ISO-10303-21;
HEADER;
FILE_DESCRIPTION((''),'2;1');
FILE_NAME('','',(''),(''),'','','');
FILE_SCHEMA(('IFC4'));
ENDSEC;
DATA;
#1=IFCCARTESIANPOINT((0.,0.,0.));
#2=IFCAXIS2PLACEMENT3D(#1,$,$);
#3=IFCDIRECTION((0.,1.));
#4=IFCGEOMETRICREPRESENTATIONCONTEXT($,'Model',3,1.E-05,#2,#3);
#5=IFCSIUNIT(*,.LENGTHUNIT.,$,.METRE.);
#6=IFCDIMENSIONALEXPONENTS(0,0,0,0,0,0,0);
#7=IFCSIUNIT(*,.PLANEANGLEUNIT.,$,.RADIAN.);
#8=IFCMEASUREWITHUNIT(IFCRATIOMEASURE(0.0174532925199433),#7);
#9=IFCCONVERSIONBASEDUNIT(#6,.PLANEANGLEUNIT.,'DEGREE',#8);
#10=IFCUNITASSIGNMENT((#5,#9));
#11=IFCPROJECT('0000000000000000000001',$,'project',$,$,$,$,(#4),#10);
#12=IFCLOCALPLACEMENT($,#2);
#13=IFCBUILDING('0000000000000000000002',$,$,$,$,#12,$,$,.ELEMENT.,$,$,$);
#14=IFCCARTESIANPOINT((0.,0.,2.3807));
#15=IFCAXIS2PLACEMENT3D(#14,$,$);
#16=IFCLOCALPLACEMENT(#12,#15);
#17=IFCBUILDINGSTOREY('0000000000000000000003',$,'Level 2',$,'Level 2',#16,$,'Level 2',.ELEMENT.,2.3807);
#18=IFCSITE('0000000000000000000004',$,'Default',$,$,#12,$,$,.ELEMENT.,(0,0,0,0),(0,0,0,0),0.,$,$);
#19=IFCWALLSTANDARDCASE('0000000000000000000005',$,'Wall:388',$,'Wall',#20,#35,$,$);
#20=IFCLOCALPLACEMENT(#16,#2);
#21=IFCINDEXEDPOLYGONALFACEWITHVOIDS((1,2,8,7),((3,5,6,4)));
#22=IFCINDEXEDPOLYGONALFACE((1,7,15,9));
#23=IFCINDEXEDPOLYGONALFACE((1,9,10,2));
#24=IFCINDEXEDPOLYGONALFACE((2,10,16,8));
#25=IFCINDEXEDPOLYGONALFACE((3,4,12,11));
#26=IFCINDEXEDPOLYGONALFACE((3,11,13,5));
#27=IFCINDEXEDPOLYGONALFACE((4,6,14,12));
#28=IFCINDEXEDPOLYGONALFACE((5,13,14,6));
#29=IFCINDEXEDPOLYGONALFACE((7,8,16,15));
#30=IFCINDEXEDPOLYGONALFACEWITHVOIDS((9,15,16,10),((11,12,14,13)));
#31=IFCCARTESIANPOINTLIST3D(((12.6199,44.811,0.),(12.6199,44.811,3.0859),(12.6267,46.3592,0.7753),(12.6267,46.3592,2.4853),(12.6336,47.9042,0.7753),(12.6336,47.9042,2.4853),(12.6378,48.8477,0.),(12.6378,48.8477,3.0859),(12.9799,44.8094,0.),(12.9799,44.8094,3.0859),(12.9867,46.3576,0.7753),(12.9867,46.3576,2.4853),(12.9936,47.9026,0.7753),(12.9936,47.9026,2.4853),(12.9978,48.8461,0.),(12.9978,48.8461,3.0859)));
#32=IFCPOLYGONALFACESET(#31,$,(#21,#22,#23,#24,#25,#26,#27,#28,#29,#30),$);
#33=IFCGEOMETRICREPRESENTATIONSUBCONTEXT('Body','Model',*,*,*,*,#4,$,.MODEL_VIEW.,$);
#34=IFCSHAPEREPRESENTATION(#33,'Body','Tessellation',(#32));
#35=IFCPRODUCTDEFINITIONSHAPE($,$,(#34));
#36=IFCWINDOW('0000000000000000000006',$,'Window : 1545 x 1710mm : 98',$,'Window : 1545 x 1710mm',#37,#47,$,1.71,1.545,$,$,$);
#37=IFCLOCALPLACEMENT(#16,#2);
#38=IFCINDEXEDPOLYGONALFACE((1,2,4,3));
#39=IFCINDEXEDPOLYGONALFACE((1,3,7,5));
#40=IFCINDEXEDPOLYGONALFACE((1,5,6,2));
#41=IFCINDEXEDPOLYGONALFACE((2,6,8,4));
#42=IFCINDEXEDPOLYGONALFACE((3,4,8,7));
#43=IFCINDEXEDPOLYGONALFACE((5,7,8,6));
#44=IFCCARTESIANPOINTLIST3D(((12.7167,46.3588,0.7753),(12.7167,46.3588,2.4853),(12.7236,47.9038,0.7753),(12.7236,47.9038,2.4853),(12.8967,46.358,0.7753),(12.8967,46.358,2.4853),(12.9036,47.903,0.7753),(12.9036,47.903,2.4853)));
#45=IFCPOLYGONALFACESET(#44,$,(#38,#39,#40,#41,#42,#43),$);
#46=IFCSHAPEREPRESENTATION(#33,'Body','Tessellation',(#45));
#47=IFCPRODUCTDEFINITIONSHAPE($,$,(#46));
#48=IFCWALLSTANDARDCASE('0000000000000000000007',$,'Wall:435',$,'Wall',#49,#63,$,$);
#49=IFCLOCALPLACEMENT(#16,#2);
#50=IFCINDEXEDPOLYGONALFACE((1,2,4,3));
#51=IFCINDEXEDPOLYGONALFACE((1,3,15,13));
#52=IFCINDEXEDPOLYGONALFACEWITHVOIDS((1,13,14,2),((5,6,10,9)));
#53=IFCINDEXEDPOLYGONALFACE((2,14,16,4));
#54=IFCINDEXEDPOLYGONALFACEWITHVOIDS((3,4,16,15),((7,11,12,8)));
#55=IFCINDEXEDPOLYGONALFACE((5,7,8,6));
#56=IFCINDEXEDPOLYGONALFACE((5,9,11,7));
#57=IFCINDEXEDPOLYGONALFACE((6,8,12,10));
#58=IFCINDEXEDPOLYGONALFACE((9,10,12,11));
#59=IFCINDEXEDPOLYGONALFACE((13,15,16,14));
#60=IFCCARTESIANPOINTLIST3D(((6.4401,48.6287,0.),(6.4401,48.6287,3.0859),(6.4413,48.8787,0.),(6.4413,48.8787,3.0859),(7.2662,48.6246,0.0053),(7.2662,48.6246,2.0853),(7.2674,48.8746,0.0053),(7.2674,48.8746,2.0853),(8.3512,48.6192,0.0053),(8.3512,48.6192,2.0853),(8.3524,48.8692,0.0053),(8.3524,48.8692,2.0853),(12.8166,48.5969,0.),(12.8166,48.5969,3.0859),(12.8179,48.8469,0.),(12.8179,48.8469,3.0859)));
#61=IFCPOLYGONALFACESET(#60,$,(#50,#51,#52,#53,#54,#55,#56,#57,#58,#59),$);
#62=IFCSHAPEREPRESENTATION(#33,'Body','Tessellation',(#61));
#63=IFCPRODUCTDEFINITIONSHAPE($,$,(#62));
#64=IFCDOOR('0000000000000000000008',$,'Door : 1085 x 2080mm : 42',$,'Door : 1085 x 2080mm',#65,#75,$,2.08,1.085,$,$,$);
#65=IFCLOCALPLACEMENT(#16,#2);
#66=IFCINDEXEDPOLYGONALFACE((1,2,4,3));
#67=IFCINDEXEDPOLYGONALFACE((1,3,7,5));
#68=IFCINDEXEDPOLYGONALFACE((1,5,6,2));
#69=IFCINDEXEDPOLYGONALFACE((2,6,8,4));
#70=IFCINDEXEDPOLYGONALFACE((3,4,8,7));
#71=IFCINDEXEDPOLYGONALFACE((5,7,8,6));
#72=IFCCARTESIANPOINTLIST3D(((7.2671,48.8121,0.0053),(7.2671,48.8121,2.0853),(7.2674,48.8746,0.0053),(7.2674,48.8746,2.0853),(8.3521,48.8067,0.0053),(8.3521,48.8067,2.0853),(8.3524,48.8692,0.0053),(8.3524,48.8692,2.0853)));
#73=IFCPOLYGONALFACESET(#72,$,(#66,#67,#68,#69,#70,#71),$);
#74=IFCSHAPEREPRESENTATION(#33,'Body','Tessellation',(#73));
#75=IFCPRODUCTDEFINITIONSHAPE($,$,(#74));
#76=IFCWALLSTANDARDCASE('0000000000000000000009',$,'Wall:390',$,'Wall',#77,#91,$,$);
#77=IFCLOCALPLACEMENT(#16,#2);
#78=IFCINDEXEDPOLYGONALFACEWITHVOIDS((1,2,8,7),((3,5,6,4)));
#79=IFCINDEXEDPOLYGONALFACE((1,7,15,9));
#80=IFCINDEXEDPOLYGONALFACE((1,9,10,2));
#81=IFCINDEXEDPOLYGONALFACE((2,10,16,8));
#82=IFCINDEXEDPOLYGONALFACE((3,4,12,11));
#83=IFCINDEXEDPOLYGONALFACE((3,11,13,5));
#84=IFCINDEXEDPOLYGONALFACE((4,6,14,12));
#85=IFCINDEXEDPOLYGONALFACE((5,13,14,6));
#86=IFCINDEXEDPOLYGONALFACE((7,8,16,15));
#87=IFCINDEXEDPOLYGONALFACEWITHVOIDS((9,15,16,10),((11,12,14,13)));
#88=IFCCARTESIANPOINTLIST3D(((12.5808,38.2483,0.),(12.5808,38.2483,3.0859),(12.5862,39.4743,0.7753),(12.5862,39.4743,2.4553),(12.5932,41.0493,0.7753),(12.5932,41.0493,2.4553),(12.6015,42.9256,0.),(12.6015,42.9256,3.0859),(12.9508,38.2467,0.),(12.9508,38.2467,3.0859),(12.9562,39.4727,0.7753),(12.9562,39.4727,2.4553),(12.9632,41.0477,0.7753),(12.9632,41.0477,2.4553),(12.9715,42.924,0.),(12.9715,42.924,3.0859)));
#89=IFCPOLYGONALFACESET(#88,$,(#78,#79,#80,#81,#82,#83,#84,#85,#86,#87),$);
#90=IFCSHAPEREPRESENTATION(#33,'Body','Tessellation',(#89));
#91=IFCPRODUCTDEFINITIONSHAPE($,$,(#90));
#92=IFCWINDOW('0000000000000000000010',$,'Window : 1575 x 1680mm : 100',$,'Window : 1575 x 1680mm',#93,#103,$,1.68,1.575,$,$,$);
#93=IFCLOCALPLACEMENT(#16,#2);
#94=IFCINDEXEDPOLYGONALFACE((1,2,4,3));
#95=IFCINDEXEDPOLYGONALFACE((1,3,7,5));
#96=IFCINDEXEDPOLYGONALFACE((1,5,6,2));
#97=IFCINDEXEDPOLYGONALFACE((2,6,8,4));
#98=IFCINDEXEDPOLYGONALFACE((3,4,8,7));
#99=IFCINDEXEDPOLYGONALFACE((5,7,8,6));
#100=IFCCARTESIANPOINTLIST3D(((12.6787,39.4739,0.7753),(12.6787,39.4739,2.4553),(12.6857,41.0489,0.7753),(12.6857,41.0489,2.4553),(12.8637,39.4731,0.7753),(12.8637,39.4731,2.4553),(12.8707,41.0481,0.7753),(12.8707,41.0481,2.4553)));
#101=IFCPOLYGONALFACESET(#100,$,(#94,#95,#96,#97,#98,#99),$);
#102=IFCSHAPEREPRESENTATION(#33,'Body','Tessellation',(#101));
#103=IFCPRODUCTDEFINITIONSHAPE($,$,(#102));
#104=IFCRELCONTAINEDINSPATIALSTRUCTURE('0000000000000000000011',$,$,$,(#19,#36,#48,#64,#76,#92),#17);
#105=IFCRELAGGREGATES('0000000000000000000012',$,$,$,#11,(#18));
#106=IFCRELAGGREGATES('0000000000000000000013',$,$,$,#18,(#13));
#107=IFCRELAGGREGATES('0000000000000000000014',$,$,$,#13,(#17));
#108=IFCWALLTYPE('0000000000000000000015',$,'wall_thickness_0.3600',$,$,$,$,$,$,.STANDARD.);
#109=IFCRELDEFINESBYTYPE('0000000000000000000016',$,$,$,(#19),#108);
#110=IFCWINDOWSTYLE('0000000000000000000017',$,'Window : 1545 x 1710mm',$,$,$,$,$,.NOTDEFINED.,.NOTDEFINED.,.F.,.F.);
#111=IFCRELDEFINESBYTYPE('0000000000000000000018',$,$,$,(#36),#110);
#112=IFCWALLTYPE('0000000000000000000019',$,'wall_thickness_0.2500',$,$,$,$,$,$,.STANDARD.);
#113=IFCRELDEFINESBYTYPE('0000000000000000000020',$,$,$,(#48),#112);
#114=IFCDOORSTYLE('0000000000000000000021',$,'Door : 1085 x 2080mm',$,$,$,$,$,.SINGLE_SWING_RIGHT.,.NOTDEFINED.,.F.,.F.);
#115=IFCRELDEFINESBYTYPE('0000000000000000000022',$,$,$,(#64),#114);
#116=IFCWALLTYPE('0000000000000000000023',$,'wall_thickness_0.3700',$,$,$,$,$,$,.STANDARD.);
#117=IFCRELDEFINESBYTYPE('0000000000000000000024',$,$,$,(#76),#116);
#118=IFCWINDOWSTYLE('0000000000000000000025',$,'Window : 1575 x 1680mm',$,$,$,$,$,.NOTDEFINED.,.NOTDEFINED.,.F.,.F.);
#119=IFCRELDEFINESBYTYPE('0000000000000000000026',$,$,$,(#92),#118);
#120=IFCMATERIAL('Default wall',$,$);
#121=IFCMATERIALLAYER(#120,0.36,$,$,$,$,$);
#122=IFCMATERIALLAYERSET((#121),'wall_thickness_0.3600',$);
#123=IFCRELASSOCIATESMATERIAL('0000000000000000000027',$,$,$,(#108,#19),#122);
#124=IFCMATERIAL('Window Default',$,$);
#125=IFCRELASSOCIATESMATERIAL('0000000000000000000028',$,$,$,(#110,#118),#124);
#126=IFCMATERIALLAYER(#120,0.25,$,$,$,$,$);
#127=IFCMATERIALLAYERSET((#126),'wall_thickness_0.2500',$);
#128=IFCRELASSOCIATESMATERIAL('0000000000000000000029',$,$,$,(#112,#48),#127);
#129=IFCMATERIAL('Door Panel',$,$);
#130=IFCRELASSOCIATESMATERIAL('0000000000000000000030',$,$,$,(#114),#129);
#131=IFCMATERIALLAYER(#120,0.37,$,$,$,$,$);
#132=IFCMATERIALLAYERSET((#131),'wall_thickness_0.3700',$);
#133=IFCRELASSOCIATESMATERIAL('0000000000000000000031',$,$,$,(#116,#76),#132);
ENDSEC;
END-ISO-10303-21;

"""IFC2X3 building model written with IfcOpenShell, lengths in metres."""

from ifc_helpers import new_model, entity, si_unit, converted_unit, direction, frame, frame_2d, origin, origin_2d_with_axis, place, context, subcontext, project, spatial, polyline, rectangle, outline, extrude, source, transform, mapped, material, layer, layer_set, layer_usage, type_object, type_shapes, element, fill, save


model = new_model("IFC2X3")

# Units and contexts
model_context = context("Model", 3, precision=1e-05, world=origin(), true_north=direction((0.0, 1.0)))
body_context = subcontext(model_context, "Body", "Model", "MODEL_VIEW")
ifc_project = project(units=[si_unit("LENGTHUNIT", "METRE"), converted_unit("PLANEANGLEUNIT", "DEGREE", entity("IfcRatioMeasure", 0.0174532925199433), si_unit("PLANEANGLEUNIT", "RADIAN"), dimensions=[0, 0, 0, 0, 0, 0, 0])], contexts=[model_context])

# Site, building, storey
placement_1 = place(None, origin())
site = spatial("IfcSite", under=ifc_project, at=placement_1, Name="Default", CompositionType="ELEMENT", RefLatitude=(0, 0, 0, 0), RefLongitude=(0, 0, 0, 0), RefElevation=0.0)
building = spatial("IfcBuilding", under=site, at=placement_1, CompositionType="ELEMENT")
storey_placement = place(placement_1, frame((0.0, 0.0, 2.3807)))
storey = spatial("IfcBuildingStorey", under=building, at=storey_placement, Name="Level 2", ObjectType="Level 2", LongName="Level 2", CompositionType="ELEMENT", Elevation=2.3807)

# Wall, opening, window
ifc_material_1 = material(Name="Default wall")
ifc_layer_1 = layer(ifc_material_1, 0.36)
ifc_layer_set_1 = layer_set([ifc_layer_1], Name="wall_thickness_0.3600")
ifc_layer_usage_1 = layer_usage(ifc_layer_set_1, "AXIS2", "POSITIVE", -0.18)
wall_type_1 = type_object("IfcWallType", Name="wall_thickness_0.3600", PredefinedType="STANDARD", material=ifc_layer_set_1)
wall_1_placement = place(storey_placement, frame((12.8178, 48.8469, 0.0), z_axis=(0.0, 0.0, 1.0), x_axis=(-0.004434, -0.99999, 0.0)))
wall_1 = element("IfcWallStandardCase", 1, at=wall_1_placement, inside=storey, type_object=wall_type_1, material=ifc_layer_usage_1, Name="Wall:388", ObjectType="Wall", context=body_context, shape_type="SweptSolid", body=[
    extrude(outline(polyline([(4.0368, -0.18), (4.0368, 0.18), (0.0, 0.18), (0.0, -0.18), (4.0368, -0.18)])), origin(), (0.0, 0.0, 1.0), 3.0859),
])
opening_1_placement = place(wall_1_placement, frame((0.9435, -0.18, 0.7753)))
opening_1 = element("IfcOpeningElement", 2, at=opening_1_placement, cuts=wall_1, ObjectType="Opening", context=body_context, shape_type="SweptSolid", body=[
    extrude(rectangle(XDim=1.545, YDim=1.71, at=frame_2d((0.855, 0.7725), x_axis=(0.0, 1.0))), frame((0.0, 0.0, 0.0), z_axis=(0.0, 1.0, 0.0), x_axis=(0.0, 0.0, 1.0)), (0.0, 0.0, 1.0), 0.36),
])
ifc_material_2 = material(Name="Window Default")
window_style_1 = type_object("IfcWindowStyle", Name="Window : 1545 x 1710mm", ConstructionType="NOTDEFINED", OperationType="NOTDEFINED", ParameterTakesPrecedence=False, Sizeable=False, material=ifc_material_2)
shared_shape_1 = source(origin(), body_context, "Body", "SweptSolid", [
    extrude(rectangle(XDim=0.18, YDim=1.545, at=origin_2d_with_axis()), frame((0.7725, 0.18, 0.0), z_axis=(0.0, 0.0, 1.0), x_axis=(0.0, 1.0, 0.0)), (0.0, 0.0, 1.0), 1.71),
])
type_shapes(window_style_1, [shared_shape_1])
window_1_placement = place(opening_1_placement, origin())
window_1 = element("IfcWindow", 3, at=window_1_placement, inside=storey, type_object=window_style_1, Name="Window : 1545 x 1710mm : 98", ObjectType="Window : 1545 x 1710mm", OverallHeight=1.71, OverallWidth=1.545, context=body_context, shape_type="MappedRepresentation", body=[
    mapped(shared_shape_1, transform((0.0, 0.0, 0.0), scale=1.0)),
])
fill(opening_1, window_1)

# Wall, opening, door
ifc_layer_2 = layer(ifc_material_1, 0.25)
ifc_layer_set_2 = layer_set([ifc_layer_2], Name="wall_thickness_0.2500")
ifc_layer_usage_2 = layer_usage(ifc_layer_set_2, "AXIS2", "POSITIVE", -0.125)
wall_type_2 = type_object("IfcWallType", Name="wall_thickness_0.2500", PredefinedType="STANDARD", material=ifc_layer_set_2)
wall_2_placement = place(storey_placement, frame((6.4407, 48.7537, 0.0), z_axis=(0.0, 0.0, 1.0), x_axis=(0.999988, -0.004987, 0.0)))
wall_2 = element("IfcWallStandardCase", 4, at=wall_2_placement, inside=storey, type_object=wall_type_2, material=ifc_layer_usage_2, Name="Wall:435", ObjectType="Wall", context=body_context, shape_type="SweptSolid", body=[
    extrude(outline(polyline([(6.3766, -0.125), (6.3766, 0.125), (0.0, 0.125), (0.0, -0.125), (6.3766, -0.125)])), origin(), (0.0, 0.0, 1.0), 3.0859),
])
opening_2_placement = place(wall_2_placement, frame((0.8261, -0.125, 0.0053)))
opening_2 = element("IfcOpeningElement", 5, at=opening_2_placement, cuts=wall_2, ObjectType="Opening", context=body_context, shape_type="SweptSolid", body=[
    extrude(rectangle(XDim=1.085, YDim=2.08, at=frame_2d((1.04, 0.5425), x_axis=(0.0, 1.0))), frame((0.0, 0.0, 0.0), z_axis=(0.0, 1.0, 0.0), x_axis=(0.0, 0.0, 1.0)), (0.0, 0.0, 1.0), 0.25),
])
ifc_material_3 = material(Name="Door Panel")
door_style = type_object("IfcDoorStyle", Name="Door : 1085 x 2080mm", ConstructionType="NOTDEFINED", OperationType="SINGLE_SWING_RIGHT", ParameterTakesPrecedence=False, Sizeable=False, material=ifc_material_3)
shared_shape_2 = source(origin(), body_context, "Body", "SweptSolid", [
    extrude(rectangle(XDim=0.0625, YDim=1.085, at=origin_2d_with_axis()), frame((0.5425, 0.2188, 0.0), z_axis=(0.0, 0.0, 1.0), x_axis=(0.0, 1.0, 0.0)), (0.0, 0.0, 1.0), 2.08),
])
type_shapes(door_style, [shared_shape_2])
door_placement = place(opening_2_placement, origin())
door = element("IfcDoor", 6, at=door_placement, inside=storey, type_object=door_style, Name="Door : 1085 x 2080mm : 42", ObjectType="Door : 1085 x 2080mm", OverallHeight=2.08, OverallWidth=1.085, context=body_context, shape_type="MappedRepresentation", body=[
    mapped(shared_shape_2, transform((0.0, 0.0, 0.0), scale=1.0)),
])
fill(opening_2, door)

# Wall, opening, window
ifc_layer_3 = layer(ifc_material_1, 0.37)
ifc_layer_set_3 = layer_set([ifc_layer_3], Name="wall_thickness_0.3700")
ifc_layer_usage_3 = layer_usage(ifc_layer_set_3, "AXIS2", "POSITIVE", -0.185)
wall_type_3 = type_object("IfcWallType", Name="wall_thickness_0.3700", PredefinedType="STANDARD", material=ifc_layer_set_3)
wall_3_placement = place(storey_placement, frame((12.7865, 42.9248, 0.0), z_axis=(0.0, 0.0, 1.0), x_axis=(-0.004434, -0.99999, 0.0)))
wall_3 = element("IfcWallStandardCase", 7, at=wall_3_placement, inside=storey, type_object=wall_type_3, material=ifc_layer_usage_3, Name="Wall:390", ObjectType="Wall", context=body_context, shape_type="SweptSolid", body=[
    extrude(outline(polyline([(4.6773, -0.185), (4.6773, 0.185), (0.0, 0.185), (0.0, -0.185), (4.6773, -0.185)])), origin(), (0.0, 0.0, 1.0), 3.0859),
])
opening_3_placement = place(wall_3_placement, frame((1.8763, -0.185, 0.7753)))
opening_3 = element("IfcOpeningElement", 8, at=opening_3_placement, cuts=wall_3, ObjectType="Opening", context=body_context, shape_type="SweptSolid", body=[
    extrude(rectangle(XDim=1.575, YDim=1.68, at=frame_2d((0.84, 0.7875), x_axis=(0.0, 1.0))), frame((0.0, 0.0, 0.0), z_axis=(0.0, 1.0, 0.0), x_axis=(0.0, 0.0, 1.0)), (0.0, 0.0, 1.0), 0.37),
])
window_style_2 = type_object("IfcWindowStyle", Name="Window : 1575 x 1680mm", ConstructionType="NOTDEFINED", OperationType="NOTDEFINED", ParameterTakesPrecedence=False, Sizeable=False, material=ifc_material_2)
shared_shape_3 = source(origin(), body_context, "Body", "SweptSolid", [
    extrude(rectangle(XDim=0.185, YDim=1.575, at=origin_2d_with_axis()), frame((0.7875, 0.185, 0.0), z_axis=(0.0, 0.0, 1.0), x_axis=(0.0, 1.0, 0.0)), (0.0, 0.0, 1.0), 1.68),
])
type_shapes(window_style_2, [shared_shape_3])
window_2_placement = place(opening_3_placement, origin())
window_2 = element("IfcWindow", 9, at=window_2_placement, inside=storey, type_object=window_style_2, Name="Window : 1575 x 1680mm : 100", ObjectType="Window : 1575 x 1680mm", OverallHeight=1.68, OverallWidth=1.575, context=body_context, shape_type="MappedRepresentation", body=[
    mapped(shared_shape_3, transform((0.0, 0.0, 0.0), scale=1.0)),
])
fill(opening_3, window_2)

save(model, "model.ifc")
